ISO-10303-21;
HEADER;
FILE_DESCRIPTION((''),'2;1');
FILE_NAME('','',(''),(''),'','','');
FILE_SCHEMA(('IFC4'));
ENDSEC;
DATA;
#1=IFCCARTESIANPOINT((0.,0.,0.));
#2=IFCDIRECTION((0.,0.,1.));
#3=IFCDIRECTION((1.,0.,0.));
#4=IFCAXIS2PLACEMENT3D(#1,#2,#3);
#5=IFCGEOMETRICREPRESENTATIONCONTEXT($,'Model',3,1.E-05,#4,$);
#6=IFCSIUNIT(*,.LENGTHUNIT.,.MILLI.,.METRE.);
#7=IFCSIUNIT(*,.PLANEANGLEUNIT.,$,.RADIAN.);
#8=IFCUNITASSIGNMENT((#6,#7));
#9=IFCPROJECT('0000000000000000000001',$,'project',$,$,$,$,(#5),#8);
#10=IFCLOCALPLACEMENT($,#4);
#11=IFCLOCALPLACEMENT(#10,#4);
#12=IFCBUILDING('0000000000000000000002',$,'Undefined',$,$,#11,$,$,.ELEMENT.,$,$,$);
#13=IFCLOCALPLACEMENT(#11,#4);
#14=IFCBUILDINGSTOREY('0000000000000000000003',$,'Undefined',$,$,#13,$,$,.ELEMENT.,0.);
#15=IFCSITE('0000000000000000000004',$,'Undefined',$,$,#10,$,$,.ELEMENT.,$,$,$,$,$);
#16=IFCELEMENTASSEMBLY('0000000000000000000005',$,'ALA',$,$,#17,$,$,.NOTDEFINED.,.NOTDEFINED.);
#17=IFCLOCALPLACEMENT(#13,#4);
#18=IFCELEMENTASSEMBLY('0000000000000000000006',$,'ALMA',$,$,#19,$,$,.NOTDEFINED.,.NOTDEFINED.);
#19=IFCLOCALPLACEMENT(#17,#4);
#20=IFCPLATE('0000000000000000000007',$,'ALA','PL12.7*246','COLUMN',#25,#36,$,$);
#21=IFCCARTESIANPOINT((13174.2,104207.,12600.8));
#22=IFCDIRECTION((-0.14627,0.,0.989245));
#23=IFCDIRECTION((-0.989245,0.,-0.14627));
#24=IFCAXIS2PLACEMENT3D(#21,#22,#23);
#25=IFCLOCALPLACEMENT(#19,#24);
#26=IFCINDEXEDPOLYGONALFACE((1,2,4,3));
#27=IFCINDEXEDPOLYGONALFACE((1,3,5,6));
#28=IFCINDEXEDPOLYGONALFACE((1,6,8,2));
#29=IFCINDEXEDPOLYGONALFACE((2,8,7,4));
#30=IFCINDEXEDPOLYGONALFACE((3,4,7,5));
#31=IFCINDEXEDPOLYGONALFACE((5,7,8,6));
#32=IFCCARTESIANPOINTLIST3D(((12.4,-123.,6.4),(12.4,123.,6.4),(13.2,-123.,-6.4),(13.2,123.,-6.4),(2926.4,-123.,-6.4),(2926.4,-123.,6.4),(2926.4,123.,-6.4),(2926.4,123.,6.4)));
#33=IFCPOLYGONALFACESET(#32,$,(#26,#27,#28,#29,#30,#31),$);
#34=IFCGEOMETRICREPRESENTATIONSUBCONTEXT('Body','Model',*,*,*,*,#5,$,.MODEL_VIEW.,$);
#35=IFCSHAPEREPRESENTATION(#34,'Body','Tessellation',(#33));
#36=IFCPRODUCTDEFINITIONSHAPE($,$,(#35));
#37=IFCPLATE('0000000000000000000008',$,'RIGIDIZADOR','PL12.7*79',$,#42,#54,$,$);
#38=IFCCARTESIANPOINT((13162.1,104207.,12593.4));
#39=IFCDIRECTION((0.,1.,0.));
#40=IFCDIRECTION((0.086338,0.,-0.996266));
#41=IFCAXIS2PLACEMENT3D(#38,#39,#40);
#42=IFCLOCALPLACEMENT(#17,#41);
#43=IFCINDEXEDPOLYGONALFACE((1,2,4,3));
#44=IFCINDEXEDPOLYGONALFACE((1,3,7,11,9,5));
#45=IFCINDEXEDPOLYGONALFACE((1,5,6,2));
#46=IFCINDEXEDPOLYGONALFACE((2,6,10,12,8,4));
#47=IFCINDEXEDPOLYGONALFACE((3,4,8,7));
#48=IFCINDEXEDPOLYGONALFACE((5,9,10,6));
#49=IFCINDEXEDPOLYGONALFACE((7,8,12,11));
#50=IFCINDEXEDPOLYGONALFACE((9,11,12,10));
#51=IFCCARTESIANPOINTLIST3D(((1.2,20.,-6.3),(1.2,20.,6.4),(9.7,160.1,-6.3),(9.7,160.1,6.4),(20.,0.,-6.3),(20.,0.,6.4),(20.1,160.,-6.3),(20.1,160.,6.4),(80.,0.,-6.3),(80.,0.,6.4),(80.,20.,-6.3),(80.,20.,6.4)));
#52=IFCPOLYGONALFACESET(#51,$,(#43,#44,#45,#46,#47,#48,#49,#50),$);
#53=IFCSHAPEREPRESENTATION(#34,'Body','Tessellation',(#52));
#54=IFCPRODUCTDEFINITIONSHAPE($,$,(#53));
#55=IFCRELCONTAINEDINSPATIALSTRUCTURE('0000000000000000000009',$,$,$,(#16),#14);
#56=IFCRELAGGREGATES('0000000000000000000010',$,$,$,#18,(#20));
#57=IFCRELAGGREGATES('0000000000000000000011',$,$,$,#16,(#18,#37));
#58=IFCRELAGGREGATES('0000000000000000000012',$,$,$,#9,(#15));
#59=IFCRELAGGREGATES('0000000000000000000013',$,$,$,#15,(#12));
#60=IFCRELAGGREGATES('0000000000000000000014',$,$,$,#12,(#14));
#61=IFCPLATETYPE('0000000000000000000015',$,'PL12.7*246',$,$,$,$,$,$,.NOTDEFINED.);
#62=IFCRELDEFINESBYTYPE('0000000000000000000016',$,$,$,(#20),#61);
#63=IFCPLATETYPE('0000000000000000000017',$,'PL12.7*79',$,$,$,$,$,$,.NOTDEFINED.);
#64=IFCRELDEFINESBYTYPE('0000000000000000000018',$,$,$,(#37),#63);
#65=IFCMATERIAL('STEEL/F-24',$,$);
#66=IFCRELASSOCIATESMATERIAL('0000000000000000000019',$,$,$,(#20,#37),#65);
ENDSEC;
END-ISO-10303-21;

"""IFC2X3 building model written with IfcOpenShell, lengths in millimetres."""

from ifc_helpers import new_model, si_unit, frame, origin_with_axes, place, context, subcontext, project, spatial, polyline, outline, extrude, clip, halfspace, material, type_object, element, aggregate, save


model = new_model("IFC2X3")

# Units and contexts
model_context = context("Model", 3, precision=1e-05, world=origin_with_axes())
body_context = subcontext(model_context, "Body", "Model", "MODEL_VIEW")
ifc_project = project(units=[si_unit("LENGTHUNIT", "METRE", prefix="MILLI"), si_unit("PLANEANGLEUNIT", "RADIAN")], contexts=[model_context])

# Site, building, storey
site_placement = place(None, origin_with_axes())
site = spatial("IfcSite", under=ifc_project, at=site_placement, Name="Undefined", CompositionType="ELEMENT")
building_placement = place(site_placement, origin_with_axes())
building = spatial("IfcBuilding", under=site, at=building_placement, Name="Undefined", CompositionType="ELEMENT")
storey_placement = place(building_placement, origin_with_axes())
storey = spatial("IfcBuildingStorey", under=building, at=storey_placement, Name="Undefined", CompositionType="ELEMENT", Elevation=0.0)

# Element assembly
ifc_material_1 = material(Name="STEEL/F-24")
assembly_1_placement = place(storey_placement, origin_with_axes())
assembly_1 = element("IfcElementAssembly", 1, at=assembly_1_placement, inside=storey, Name="ALA", AssemblyPlace="NOTDEFINED", PredefinedType="NOTDEFINED")

# Element assembly, plate
assembly_2_placement = place(assembly_1_placement, origin_with_axes())
assembly_2 = element("IfcElementAssembly", 2, at=assembly_2_placement, Name="ALMA", AssemblyPlace="NOTDEFINED", PredefinedType="NOTDEFINED")
plate_type_1 = type_object("IfcPlateType", Name="PL12.7*246", PredefinedType="NOTDEFINED")
plate_1_placement = place(assembly_2_placement, frame((13174.2, 104207.0, 12600.8), z_axis=(-0.14627, 0.0, 0.989245), x_axis=(-0.989245, 0.0, -0.14627)))
plate_1 = element("IfcPlate", 3, at=plate_1_placement, type_object=plate_type_1, material=ifc_material_1, Name="ALA", Description="PL12.7*246", ObjectType="COLUMN", context=body_context, shape_type="Clipping", body=[
    clip(extrude(outline(polyline([(12.4, -123.0), (12.4, 123.0), (2926.4, 123.0), (2926.4, -123.0), (12.4, -123.0)])), frame((0.0, 0.0, -6.3), z_axis=(0.0, 0.0, 1.0), x_axis=(1.0, 0.0, 0.0)), (0.0, 0.0, 1.0), 12.7), halfspace(frame((12.8, 0.0, 0.0), z_axis=(0.998229, 0.0, 0.059495), x_axis=(0.0, 1.0, 0.0)), True)),
])
aggregate(assembly_2, [plate_1])

# Plate
plate_type_2 = type_object("IfcPlateType", Name="PL12.7*79", PredefinedType="NOTDEFINED")
plate_2_placement = place(assembly_1_placement, frame((13162.1, 104207.0, 12593.4), z_axis=(0.0, 1.0, 0.0), x_axis=(0.086338, 0.0, -0.996266)))
plate_2 = element("IfcPlate", 4, at=plate_2_placement, type_object=plate_type_2, material=ifc_material_1, Name="RIGIDIZADOR", Description="PL12.7*79", context=body_context, shape_type="SweptSolid", body=[
    extrude(outline(polyline([(1.2, 20.0), (20.0, 0.0), (80.0, 0.0), (80.0, 20.0), (20.1, 160.0), (9.7, 160.1), (1.2, 20.0)])), frame((0.0, 0.0, -6.3), z_axis=(0.0, 0.0, 1.0), x_axis=(1.0, 0.0, 0.0)), (0.0, 0.0, 1.0), 12.7),
])
aggregate(assembly_1, [assembly_2, plate_2])

save(model, "model.ifc")
